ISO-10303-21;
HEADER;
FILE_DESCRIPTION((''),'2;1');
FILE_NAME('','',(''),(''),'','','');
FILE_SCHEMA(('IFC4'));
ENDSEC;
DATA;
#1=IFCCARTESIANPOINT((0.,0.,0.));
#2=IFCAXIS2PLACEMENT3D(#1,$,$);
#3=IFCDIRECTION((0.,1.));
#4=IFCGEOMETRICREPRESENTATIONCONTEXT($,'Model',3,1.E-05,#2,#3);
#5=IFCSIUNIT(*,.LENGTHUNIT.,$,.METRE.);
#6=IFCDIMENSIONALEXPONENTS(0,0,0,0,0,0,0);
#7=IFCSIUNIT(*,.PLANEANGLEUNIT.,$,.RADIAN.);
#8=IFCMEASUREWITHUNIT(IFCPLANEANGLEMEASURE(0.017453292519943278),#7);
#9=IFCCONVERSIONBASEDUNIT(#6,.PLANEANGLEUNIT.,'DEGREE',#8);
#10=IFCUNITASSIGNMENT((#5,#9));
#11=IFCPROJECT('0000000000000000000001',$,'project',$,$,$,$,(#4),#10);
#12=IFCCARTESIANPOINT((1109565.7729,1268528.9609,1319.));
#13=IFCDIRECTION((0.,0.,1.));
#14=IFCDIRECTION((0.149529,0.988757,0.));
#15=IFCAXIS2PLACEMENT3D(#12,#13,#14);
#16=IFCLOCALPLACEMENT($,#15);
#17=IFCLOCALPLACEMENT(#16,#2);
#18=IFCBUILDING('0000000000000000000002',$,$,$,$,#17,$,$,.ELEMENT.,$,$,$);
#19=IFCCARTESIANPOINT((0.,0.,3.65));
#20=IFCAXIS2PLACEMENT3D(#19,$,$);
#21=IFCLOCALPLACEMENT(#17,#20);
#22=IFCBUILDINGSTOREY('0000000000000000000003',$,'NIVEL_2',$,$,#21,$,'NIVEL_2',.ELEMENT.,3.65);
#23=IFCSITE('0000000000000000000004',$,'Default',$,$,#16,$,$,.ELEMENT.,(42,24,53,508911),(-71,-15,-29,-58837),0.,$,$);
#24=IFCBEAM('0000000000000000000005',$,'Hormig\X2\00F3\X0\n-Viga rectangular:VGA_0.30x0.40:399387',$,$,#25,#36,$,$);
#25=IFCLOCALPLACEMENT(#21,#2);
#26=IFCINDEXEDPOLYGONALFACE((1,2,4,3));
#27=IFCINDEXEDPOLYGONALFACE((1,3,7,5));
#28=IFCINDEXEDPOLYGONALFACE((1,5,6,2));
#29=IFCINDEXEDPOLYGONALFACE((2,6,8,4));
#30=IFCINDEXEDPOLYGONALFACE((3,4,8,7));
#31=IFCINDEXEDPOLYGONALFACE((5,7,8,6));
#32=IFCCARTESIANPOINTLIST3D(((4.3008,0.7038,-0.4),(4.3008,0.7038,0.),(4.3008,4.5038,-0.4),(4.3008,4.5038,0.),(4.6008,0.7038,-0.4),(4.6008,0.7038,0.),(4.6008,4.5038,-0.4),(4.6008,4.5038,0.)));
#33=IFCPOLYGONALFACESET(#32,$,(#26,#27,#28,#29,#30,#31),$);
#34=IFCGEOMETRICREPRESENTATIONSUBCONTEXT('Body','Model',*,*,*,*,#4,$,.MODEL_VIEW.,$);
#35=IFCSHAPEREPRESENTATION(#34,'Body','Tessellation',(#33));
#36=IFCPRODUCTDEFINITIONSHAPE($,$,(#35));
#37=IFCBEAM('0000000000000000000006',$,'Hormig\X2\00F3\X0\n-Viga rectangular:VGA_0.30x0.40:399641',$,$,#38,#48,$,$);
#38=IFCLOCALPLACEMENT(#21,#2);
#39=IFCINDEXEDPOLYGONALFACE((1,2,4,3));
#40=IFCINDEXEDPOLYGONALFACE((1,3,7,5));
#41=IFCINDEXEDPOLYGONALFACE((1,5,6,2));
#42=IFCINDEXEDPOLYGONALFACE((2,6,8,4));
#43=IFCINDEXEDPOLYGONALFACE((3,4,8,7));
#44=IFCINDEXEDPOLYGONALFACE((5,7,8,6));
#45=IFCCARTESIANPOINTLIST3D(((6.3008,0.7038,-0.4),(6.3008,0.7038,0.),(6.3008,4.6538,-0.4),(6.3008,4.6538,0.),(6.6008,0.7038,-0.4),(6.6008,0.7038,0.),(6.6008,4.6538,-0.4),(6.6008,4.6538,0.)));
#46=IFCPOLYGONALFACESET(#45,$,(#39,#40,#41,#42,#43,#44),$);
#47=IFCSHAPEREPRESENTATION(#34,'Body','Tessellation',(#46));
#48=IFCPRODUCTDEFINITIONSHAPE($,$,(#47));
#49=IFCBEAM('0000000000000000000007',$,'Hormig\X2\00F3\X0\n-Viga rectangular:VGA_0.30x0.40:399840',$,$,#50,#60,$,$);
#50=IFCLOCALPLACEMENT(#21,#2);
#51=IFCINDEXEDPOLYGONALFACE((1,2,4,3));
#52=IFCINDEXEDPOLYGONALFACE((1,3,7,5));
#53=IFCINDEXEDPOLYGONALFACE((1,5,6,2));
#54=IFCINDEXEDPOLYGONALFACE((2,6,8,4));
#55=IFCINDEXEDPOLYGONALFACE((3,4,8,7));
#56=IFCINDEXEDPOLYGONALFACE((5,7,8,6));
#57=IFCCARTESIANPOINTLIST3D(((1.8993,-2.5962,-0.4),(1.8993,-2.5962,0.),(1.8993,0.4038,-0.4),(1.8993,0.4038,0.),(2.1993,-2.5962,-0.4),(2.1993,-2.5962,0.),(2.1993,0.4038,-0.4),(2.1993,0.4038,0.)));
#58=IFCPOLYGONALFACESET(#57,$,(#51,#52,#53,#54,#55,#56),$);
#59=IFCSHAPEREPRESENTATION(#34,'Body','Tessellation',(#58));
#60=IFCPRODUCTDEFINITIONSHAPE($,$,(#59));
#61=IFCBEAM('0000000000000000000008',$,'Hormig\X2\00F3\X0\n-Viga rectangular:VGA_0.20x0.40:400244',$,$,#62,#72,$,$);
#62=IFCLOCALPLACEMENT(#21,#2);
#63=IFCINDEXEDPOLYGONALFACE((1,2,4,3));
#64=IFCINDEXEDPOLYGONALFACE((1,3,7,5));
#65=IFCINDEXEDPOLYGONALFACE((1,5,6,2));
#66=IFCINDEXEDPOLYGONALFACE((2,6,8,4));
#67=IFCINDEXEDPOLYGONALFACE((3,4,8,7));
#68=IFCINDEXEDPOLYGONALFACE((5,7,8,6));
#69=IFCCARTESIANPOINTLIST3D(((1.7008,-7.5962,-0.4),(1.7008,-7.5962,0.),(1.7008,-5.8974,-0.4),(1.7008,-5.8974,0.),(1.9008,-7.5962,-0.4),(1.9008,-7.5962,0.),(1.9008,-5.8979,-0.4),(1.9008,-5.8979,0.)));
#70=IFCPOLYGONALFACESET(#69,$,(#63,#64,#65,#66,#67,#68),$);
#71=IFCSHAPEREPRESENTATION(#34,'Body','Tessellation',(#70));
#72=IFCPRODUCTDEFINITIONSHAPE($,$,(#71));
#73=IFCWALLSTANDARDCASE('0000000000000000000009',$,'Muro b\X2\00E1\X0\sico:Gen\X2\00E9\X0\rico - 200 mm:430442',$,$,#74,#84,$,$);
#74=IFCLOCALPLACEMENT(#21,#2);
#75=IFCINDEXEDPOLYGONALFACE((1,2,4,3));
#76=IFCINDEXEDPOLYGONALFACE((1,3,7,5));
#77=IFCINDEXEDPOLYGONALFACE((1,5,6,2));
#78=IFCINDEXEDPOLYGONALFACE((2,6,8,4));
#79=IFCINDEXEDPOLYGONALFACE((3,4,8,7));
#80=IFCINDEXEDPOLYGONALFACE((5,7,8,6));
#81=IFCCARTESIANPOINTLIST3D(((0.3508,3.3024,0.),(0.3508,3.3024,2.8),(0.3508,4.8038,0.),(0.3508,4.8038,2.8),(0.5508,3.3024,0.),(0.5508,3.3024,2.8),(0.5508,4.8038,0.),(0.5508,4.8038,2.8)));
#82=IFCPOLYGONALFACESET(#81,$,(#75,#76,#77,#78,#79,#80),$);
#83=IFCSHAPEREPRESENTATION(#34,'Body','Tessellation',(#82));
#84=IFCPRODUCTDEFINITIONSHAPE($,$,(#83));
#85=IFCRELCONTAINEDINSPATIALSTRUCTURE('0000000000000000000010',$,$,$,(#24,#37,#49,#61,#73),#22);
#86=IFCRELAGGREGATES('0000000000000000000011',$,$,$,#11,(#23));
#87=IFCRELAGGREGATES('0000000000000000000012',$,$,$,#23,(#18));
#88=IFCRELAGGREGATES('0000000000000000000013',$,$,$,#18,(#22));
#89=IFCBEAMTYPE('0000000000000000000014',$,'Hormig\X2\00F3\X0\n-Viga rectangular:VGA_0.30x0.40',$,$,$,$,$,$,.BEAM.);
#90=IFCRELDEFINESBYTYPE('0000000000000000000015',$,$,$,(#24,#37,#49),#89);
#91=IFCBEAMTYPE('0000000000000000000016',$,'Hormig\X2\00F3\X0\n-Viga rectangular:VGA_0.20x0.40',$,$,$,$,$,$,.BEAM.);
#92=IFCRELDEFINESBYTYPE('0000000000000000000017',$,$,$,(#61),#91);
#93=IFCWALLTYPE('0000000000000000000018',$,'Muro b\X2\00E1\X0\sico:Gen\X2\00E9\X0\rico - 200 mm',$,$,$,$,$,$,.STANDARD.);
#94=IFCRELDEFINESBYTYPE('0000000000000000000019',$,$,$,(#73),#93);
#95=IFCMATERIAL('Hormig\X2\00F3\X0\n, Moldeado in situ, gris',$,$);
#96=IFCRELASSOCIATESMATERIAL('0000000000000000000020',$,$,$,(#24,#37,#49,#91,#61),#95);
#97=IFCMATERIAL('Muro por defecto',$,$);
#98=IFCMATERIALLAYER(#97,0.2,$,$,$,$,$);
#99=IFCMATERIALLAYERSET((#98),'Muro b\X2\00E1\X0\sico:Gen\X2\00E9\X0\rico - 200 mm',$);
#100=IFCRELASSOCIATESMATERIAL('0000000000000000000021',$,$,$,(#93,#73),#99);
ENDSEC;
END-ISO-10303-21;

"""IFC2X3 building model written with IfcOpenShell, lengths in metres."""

from ifc_helpers import new_model, entity, si_unit, converted_unit, direction, frame, frame_2d, origin, origin_2d_with_axis, place, context, subcontext, project, spatial, rectangle, extrude, clip, halfspace, material, layer, layer_set, layer_usage, type_object, element, save


model = new_model("IFC2X3")

# Units and contexts
model_context = context("Model", 3, precision=1e-05, world=origin(), true_north=direction((0.0, 1.0)))
body_context = subcontext(model_context, "Body", "Model", "MODEL_VIEW")
ifc_project = project(units=[si_unit("LENGTHUNIT", "METRE"), converted_unit("PLANEANGLEUNIT", "DEGREE", entity("IfcPlaneAngleMeasure", 0.017453292519943278), si_unit("PLANEANGLEUNIT", "RADIAN"), dimensions=[0, 0, 0, 0, 0, 0, 0])], contexts=[model_context])

# Site, building, storey
site_placement = place(None, frame((1109565.7729, 1268528.9609, 1319.0), z_axis=(0.0, 0.0, 1.0), x_axis=(0.149529, 0.988757, 0.0)))
site = spatial("IfcSite", under=ifc_project, at=site_placement, Name="Default", CompositionType="ELEMENT", RefLatitude=(42, 24, 53, 508911), RefLongitude=(-71, -15, -29, -58837), RefElevation=0.0)
building_placement = place(site_placement, origin())
building = spatial("IfcBuilding", under=site, at=building_placement, CompositionType="ELEMENT")
storey_placement = place(building_placement, frame((0.0, 0.0, 3.65)))
storey = spatial("IfcBuildingStorey", under=building, at=storey_placement, Name="NIVEL_2", LongName="NIVEL_2", CompositionType="ELEMENT", Elevation=3.65)

# Shared definitions
ifc_material_1 = material(Name="Hormigón, Moldeado in situ, gris")

# Beams
beam_type_1 = type_object("IfcBeamType", Name="Hormigón-Viga rectangular:VGA_0.30x0.40", PredefinedType="BEAM")
beam_1_placement = place(storey_placement, frame((4.4508, 4.6538, 0.0), z_axis=(0.0, 0.0, 1.0), x_axis=(0.0, -1.0, 0.0)))
element("IfcBeam", 1, at=beam_1_placement, inside=storey, type_object=beam_type_1, material=ifc_material_1, Name="Hormigón-Viga rectangular:VGA_0.30x0.40:399387", context=body_context, shape_type="SweptSolid", body=[
    extrude(rectangle(XDim=0.4, YDim=0.3, at=frame_2d((0.0, 0.0), x_axis=(1.0, 0.0))), frame((0.15, 0.0, -0.2), z_axis=(1.0, 0.0, 0.0), x_axis=(0.0, 0.0, -1.0)), (0.0, 0.0, 1.0), 3.8),
])
beam_2_placement = place(storey_placement, frame((6.4508, 0.5538, 0.0), z_axis=(0.0, 0.0, 1.0), x_axis=(0.0, 1.0, 0.0)))
element("IfcBeam", 2, at=beam_2_placement, inside=storey, type_object=beam_type_1, material=ifc_material_1, Name="Hormigón-Viga rectangular:VGA_0.30x0.40:399641", context=body_context, shape_type="SweptSolid", body=[
    extrude(rectangle(XDim=0.4, YDim=0.3, at=frame_2d((0.0, 0.0), x_axis=(1.0, 0.0))), frame((0.15, 0.0, -0.2), z_axis=(1.0, 0.0, 0.0), x_axis=(0.0, 0.0, -1.0)), (0.0, 0.0, 1.0), 3.95),
])
beam_3_placement = place(storey_placement, frame((2.0493, -2.7462, 0.0), z_axis=(0.0, 0.0, 1.0), x_axis=(0.0, 1.0, 0.0)))
element("IfcBeam", 3, at=beam_3_placement, inside=storey, type_object=beam_type_1, material=ifc_material_1, Name="Hormigón-Viga rectangular:VGA_0.30x0.40:399840", context=body_context, shape_type="SweptSolid", body=[
    extrude(rectangle(XDim=0.4, YDim=0.3, at=origin_2d_with_axis()), frame((0.15, 0.0, -0.2), z_axis=(1.0, 0.0, 0.0), x_axis=(0.0, 0.0, -1.0)), (0.0, 0.0, 1.0), 3.0),
])
beam_type_2 = type_object("IfcBeamType", Name="Hormigón-Viga rectangular:VGA_0.20x0.40", PredefinedType="BEAM", material=ifc_material_1)
beam_4_placement = place(storey_placement, frame((1.8008, -7.7462, 0.0), z_axis=(0.0, 0.0, 1.0), x_axis=(0.0, 1.0, 0.0)))
element("IfcBeam", 4, at=beam_4_placement, inside=storey, type_object=beam_type_2, material=ifc_material_1, Name="Hormigón-Viga rectangular:VGA_0.20x0.40:400244", context=body_context, shape_type="Clipping", body=[
    clip(extrude(rectangle(XDim=0.4, YDim=0.2, at=origin_2d_with_axis()), frame((0.15, 0.0, -0.2), z_axis=(1.0, 0.0, 0.0), x_axis=(0.0, 0.0, -1.0)), (0.0, 0.0, 1.0), 1.6988), halfspace(frame((1.8483, -0.1, 0.0), z_axis=(0.999997, -0.002531, 0.0), x_axis=(-0.002531, -0.999997, 0.0)), False)),
])

# Wall
ifc_material_2 = material(Name="Muro por defecto")
ifc_layer = layer(ifc_material_2, 0.2)
ifc_layer_set = layer_set([ifc_layer], Name="Muro básico:Genérico - 200 mm")
ifc_layer_usage = layer_usage(ifc_layer_set, "AXIS2", "NEGATIVE", 0.1)
wall_type = type_object("IfcWallType", Name="Muro básico:Genérico - 200 mm", PredefinedType="STANDARD", material=ifc_layer_set)
wall_placement = place(storey_placement, frame((0.4508, 4.8038, 0.0), z_axis=(0.0, 0.0, 1.0), x_axis=(0.0, -1.0, 0.0)))
element("IfcWallStandardCase", 5, at=wall_placement, inside=storey, type_object=wall_type, material=ifc_layer_usage, Name="Muro básico:Genérico - 200 mm:430442", context=body_context, shape_type="SweptSolid", body=[
    extrude(rectangle(XDim=1.5014, YDim=0.2, at=frame_2d((0.7507, 0.0), x_axis=(-1.0, 0.0))), origin(), (0.0, 0.0, 1.0), 2.8),
])

save(model, "model.ifc")
